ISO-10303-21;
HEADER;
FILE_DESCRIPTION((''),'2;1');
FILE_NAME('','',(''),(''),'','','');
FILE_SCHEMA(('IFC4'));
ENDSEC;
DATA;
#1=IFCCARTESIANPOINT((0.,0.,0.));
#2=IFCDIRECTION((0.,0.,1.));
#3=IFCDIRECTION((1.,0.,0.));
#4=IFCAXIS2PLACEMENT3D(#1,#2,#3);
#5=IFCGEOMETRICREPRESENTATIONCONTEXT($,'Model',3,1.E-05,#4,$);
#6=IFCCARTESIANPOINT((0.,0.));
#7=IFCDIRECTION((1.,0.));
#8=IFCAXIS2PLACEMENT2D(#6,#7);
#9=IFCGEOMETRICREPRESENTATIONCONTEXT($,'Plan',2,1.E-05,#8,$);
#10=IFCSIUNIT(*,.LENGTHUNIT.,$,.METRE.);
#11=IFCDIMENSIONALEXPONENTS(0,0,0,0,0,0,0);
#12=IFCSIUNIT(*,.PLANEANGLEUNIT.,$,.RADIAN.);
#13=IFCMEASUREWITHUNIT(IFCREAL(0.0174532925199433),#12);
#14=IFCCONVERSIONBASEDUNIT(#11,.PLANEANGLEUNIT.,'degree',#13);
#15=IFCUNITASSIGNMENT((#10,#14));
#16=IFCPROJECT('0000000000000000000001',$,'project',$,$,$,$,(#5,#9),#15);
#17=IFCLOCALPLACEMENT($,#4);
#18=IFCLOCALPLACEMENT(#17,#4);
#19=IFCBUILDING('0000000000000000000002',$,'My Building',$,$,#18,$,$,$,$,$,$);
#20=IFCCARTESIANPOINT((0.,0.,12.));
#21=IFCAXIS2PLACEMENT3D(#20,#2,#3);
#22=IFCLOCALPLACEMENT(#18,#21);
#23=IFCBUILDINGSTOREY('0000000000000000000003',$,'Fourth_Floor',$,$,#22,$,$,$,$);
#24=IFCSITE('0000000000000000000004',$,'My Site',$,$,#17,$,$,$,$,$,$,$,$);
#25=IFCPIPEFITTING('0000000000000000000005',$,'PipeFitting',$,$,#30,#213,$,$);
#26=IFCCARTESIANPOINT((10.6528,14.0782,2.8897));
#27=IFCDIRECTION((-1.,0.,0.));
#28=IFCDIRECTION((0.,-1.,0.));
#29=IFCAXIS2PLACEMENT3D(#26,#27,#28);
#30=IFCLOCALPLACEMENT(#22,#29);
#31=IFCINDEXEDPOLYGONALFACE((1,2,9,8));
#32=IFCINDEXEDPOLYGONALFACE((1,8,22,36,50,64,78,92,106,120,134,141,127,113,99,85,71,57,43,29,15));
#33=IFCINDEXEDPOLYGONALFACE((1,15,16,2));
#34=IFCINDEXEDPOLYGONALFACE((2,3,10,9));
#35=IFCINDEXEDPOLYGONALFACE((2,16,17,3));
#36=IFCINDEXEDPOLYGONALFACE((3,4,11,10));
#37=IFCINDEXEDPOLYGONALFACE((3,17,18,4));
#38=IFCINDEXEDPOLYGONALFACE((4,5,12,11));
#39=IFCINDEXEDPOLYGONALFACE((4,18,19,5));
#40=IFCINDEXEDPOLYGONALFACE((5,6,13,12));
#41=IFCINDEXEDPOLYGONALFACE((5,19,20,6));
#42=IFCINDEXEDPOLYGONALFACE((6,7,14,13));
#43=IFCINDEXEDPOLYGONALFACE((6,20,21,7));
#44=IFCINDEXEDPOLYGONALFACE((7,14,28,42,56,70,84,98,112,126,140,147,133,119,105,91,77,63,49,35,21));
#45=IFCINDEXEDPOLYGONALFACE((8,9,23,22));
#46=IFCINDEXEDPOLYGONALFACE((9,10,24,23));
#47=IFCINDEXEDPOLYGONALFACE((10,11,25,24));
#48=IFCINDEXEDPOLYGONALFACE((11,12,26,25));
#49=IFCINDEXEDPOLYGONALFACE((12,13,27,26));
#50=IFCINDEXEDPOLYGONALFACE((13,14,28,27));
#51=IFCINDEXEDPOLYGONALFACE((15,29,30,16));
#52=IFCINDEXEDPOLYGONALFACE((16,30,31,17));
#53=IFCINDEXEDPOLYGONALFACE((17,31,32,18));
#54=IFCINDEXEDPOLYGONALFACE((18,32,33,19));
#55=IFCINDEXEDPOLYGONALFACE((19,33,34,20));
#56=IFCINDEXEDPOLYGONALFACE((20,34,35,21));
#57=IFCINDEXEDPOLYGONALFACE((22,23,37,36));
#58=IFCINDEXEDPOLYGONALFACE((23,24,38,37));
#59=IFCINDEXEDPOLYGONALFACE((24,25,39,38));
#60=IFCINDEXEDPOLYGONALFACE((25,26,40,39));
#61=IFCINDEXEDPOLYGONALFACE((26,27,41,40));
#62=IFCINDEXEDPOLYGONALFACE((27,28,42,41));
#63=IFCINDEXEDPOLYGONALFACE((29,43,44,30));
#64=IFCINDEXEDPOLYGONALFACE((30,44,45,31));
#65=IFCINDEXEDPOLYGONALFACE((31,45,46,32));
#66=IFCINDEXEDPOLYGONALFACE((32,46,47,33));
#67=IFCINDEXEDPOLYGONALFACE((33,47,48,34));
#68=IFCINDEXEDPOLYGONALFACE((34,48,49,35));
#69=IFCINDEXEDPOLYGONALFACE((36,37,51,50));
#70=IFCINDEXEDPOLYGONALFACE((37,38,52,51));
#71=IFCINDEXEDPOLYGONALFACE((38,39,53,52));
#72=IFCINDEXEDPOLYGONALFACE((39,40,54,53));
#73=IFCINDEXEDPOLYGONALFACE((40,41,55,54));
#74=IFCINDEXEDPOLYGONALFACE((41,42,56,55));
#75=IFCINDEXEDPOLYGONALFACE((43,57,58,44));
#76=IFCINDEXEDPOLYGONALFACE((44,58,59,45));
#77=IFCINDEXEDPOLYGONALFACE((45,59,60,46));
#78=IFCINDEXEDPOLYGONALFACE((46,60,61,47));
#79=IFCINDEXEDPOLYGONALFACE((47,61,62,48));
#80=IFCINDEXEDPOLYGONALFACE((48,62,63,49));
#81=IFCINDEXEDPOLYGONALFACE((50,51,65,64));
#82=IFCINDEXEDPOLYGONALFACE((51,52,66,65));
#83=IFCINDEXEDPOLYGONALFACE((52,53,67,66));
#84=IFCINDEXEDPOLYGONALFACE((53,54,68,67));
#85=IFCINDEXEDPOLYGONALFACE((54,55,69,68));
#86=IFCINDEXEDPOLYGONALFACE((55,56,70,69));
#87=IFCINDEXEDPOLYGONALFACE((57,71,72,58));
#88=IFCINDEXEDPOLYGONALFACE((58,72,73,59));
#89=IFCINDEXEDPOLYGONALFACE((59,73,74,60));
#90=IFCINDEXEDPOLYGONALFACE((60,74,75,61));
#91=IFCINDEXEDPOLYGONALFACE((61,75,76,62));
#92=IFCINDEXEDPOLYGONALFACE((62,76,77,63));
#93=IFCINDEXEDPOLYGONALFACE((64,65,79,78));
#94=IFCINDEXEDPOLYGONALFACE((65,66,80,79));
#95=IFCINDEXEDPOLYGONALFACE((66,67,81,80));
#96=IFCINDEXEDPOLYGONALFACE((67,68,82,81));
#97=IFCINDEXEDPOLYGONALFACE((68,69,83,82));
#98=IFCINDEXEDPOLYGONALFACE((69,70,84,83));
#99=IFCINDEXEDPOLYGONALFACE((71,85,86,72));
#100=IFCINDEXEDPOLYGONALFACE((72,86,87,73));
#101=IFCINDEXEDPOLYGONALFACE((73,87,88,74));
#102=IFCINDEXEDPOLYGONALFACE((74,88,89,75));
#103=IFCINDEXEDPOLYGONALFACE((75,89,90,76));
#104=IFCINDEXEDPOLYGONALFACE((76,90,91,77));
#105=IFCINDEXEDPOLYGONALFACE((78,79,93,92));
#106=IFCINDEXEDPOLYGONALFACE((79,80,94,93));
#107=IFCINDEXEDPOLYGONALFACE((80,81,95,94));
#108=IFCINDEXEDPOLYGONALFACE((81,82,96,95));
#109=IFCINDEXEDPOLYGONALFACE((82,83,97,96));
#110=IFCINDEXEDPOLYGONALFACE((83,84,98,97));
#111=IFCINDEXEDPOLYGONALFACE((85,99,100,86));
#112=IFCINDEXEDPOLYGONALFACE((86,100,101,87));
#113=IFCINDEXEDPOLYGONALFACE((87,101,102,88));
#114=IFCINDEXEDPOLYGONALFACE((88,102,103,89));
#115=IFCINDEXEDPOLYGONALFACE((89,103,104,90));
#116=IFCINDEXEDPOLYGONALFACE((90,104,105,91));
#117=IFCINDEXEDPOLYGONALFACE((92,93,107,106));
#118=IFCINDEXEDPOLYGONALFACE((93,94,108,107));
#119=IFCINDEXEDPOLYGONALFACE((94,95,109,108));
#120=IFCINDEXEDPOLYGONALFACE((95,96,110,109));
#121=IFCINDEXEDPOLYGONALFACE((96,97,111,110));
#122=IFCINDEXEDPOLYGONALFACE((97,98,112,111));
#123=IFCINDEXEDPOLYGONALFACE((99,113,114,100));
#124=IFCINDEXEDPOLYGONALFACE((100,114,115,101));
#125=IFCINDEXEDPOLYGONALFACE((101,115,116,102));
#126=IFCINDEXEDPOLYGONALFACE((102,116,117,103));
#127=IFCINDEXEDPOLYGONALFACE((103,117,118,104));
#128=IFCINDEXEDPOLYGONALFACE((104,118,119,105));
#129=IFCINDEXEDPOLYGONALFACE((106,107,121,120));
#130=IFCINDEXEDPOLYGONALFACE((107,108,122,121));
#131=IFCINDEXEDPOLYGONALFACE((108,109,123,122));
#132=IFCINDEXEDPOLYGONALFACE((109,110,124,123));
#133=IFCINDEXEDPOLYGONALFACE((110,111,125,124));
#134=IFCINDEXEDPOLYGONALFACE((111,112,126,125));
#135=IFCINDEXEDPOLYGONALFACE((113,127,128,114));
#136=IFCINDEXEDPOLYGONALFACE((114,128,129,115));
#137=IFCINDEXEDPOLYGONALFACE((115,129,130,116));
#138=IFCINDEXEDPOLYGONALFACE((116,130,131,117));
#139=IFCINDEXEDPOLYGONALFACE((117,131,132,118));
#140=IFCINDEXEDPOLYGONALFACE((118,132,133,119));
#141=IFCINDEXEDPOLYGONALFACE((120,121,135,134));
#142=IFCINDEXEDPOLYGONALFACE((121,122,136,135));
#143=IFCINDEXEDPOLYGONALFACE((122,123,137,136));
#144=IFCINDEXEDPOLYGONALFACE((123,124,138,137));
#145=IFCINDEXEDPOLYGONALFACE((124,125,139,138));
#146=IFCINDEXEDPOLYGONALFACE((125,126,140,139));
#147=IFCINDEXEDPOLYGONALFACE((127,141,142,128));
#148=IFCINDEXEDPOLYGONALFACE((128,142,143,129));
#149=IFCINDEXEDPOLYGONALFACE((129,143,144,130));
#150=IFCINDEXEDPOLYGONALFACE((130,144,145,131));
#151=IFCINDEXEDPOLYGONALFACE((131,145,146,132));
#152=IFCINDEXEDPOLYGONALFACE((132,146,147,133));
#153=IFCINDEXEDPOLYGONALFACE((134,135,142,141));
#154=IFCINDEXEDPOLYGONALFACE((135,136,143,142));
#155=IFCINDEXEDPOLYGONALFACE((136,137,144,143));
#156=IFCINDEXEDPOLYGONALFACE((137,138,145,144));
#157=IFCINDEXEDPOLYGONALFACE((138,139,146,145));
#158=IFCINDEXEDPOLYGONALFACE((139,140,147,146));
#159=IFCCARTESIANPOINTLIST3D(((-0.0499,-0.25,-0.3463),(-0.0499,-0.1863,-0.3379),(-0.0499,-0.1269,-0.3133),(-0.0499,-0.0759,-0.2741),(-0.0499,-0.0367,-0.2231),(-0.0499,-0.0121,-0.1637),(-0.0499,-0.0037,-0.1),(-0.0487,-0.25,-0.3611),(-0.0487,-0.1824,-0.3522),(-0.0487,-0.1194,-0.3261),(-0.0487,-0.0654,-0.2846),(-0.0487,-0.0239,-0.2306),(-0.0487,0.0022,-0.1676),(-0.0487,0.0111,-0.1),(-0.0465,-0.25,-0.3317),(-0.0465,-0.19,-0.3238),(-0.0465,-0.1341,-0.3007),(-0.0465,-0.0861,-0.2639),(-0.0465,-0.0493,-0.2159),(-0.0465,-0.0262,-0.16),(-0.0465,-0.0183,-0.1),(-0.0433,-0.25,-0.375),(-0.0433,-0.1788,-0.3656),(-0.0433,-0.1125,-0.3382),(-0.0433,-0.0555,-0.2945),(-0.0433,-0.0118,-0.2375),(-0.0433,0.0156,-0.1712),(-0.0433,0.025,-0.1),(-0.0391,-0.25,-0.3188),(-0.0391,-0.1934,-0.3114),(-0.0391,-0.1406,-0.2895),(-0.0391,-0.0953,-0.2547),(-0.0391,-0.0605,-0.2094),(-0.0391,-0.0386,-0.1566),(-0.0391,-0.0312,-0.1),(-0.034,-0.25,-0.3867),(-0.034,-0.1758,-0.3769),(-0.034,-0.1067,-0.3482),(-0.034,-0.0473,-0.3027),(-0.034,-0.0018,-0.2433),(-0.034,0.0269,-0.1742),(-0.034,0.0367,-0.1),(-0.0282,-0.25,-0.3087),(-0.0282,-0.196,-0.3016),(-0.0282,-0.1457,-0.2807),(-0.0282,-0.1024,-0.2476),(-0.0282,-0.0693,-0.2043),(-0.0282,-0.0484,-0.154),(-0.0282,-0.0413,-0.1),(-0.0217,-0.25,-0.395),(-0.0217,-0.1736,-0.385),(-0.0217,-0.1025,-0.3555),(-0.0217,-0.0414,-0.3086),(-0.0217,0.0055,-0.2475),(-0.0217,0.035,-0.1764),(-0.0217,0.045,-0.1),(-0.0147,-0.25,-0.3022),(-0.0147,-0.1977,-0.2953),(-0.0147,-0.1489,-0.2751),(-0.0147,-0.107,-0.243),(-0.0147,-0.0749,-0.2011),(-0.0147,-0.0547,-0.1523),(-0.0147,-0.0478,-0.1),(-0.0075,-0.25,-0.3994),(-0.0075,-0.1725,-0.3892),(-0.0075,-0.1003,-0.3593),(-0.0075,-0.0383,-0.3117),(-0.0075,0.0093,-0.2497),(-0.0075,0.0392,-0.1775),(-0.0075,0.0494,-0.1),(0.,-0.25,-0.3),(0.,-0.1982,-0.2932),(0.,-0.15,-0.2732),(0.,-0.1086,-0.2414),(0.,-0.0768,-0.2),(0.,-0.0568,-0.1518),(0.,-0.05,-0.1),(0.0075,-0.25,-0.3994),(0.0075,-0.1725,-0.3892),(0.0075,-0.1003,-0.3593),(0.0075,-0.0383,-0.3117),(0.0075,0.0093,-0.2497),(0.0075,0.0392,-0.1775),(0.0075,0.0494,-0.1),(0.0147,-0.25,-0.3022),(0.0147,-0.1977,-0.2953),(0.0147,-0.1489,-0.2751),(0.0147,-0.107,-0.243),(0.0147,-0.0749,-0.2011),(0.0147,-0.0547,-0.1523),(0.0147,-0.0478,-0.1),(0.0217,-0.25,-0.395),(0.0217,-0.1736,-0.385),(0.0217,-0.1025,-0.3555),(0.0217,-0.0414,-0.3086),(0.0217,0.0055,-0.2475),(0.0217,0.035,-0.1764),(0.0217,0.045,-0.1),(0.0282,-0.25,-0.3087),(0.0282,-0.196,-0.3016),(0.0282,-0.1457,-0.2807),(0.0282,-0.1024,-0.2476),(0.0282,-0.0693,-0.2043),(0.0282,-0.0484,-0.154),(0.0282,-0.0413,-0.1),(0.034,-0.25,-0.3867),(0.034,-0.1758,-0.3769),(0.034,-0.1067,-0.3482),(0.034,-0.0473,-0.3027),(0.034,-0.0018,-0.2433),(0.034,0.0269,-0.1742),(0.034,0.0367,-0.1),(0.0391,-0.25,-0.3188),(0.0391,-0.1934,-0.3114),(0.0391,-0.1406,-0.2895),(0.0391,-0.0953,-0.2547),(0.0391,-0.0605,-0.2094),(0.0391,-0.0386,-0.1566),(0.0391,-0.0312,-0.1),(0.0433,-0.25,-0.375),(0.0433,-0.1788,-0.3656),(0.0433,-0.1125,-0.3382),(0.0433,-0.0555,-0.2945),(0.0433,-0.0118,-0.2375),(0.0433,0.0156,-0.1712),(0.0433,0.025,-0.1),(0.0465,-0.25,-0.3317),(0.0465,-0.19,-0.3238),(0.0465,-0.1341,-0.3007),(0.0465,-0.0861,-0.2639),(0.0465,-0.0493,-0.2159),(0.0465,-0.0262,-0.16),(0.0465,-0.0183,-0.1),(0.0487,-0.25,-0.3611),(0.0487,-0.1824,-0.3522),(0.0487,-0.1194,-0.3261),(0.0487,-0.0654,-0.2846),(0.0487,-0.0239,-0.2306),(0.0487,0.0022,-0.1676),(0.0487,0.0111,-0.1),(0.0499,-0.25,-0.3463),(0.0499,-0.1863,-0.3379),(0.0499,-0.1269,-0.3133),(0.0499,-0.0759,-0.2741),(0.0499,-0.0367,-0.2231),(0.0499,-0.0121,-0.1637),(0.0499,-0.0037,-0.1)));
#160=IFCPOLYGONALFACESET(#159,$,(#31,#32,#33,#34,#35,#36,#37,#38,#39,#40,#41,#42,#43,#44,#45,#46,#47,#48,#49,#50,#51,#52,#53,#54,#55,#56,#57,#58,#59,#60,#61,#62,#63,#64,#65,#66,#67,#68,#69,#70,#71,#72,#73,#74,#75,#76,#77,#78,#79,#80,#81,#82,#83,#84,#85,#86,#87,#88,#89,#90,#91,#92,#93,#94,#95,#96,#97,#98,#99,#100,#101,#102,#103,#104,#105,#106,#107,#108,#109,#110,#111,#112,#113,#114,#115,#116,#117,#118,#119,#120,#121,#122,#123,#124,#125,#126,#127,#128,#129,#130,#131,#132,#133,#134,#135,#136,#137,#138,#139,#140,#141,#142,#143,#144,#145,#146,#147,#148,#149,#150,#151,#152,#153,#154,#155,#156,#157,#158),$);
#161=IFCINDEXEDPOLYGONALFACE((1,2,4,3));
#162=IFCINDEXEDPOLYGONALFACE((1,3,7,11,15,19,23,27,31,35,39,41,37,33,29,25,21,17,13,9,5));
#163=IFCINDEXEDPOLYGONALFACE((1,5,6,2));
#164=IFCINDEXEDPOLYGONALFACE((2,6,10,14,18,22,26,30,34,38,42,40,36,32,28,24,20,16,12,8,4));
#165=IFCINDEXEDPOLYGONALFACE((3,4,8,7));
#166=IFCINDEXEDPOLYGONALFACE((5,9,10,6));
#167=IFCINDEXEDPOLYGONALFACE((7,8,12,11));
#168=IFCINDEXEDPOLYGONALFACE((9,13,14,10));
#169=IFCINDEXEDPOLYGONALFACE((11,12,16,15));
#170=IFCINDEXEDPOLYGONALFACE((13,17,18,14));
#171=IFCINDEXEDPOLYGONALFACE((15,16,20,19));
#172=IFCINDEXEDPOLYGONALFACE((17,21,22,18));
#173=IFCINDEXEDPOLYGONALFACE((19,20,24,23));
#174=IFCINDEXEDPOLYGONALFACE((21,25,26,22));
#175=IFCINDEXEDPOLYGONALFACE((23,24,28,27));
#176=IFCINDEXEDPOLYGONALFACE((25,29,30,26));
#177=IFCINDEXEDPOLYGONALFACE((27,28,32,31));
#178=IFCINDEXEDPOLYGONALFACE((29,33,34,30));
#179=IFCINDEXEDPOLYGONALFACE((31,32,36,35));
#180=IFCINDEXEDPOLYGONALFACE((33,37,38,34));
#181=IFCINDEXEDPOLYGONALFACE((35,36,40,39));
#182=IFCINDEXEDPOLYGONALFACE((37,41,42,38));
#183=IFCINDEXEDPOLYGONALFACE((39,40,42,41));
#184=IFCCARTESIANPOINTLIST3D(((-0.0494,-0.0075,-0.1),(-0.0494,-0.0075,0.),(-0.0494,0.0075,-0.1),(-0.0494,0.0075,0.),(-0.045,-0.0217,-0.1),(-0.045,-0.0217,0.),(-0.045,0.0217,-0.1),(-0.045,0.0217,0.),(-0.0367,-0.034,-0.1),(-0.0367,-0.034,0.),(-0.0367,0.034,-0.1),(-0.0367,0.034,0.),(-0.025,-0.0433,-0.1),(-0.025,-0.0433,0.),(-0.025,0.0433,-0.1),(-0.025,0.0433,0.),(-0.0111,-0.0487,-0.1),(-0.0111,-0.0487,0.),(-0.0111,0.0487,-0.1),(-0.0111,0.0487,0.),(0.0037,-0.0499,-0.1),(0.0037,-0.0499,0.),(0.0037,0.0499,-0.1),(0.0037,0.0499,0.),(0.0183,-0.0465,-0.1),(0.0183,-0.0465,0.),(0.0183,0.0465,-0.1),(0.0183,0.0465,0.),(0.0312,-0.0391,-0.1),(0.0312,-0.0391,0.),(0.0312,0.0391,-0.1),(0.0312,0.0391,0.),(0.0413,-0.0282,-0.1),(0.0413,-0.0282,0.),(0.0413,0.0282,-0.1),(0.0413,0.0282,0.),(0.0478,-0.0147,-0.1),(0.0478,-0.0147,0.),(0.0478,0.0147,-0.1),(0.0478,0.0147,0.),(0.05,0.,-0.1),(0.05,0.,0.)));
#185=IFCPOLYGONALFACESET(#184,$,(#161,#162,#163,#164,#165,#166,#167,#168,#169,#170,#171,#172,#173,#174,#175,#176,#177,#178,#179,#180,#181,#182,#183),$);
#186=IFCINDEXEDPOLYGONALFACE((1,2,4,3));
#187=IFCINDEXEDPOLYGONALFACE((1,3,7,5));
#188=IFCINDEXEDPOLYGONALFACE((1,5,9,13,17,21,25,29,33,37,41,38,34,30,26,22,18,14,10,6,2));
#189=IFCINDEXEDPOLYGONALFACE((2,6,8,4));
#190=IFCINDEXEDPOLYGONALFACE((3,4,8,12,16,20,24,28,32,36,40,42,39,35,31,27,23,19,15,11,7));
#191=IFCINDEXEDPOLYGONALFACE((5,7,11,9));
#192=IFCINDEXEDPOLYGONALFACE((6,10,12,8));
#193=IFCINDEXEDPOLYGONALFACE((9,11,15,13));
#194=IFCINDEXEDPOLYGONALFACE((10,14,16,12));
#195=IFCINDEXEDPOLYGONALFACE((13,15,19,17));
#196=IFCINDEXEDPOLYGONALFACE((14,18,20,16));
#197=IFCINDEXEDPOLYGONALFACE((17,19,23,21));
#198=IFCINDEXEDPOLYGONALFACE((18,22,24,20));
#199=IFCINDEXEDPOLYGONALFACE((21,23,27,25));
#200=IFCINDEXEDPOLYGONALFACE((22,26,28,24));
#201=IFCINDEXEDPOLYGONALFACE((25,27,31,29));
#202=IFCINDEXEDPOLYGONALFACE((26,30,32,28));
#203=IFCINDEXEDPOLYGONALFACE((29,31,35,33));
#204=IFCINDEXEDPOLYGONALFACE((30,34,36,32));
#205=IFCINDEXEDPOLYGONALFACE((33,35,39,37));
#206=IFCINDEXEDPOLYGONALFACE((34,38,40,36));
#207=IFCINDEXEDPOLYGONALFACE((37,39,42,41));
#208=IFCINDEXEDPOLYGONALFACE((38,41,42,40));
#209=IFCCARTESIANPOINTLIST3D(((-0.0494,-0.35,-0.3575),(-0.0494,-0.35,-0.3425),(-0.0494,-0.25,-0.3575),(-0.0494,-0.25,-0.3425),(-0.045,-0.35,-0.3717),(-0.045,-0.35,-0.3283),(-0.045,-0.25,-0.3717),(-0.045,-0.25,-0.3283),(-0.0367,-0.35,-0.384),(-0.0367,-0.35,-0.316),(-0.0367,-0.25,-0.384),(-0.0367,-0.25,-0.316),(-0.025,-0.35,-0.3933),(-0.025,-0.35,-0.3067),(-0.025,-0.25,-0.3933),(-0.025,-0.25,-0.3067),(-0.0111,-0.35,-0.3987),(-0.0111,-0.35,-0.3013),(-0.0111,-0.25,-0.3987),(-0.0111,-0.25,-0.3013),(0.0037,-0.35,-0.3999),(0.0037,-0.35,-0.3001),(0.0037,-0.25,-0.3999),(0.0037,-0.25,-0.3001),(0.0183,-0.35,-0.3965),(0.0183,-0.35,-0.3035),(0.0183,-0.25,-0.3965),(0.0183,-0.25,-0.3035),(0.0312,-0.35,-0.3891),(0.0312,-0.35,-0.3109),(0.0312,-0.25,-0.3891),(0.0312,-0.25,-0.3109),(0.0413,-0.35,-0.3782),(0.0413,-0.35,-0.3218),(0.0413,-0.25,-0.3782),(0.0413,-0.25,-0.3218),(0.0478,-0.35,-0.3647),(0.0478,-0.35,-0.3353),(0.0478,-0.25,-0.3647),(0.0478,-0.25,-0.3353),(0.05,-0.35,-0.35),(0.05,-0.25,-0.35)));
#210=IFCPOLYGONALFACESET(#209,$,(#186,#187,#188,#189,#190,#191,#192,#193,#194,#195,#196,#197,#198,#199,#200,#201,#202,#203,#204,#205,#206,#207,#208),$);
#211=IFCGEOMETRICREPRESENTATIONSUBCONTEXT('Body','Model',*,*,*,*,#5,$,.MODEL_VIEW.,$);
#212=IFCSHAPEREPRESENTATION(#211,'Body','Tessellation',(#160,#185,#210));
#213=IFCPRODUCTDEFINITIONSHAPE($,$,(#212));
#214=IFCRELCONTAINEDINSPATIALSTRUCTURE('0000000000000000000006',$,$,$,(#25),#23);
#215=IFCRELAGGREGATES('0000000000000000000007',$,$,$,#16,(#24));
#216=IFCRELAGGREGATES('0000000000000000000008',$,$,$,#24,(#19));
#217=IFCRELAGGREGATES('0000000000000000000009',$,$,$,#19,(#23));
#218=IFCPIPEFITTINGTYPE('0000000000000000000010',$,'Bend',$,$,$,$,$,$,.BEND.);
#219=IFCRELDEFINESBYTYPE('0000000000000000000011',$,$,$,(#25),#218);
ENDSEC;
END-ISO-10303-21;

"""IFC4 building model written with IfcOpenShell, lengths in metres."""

from ifc_helpers import new_model, entity, si_unit, converted_unit, frame, origin_with_axes, origin_2d_with_axis, place, context, subcontext, project, spatial, circle, extrude, source, transform, mapped, type_object, type_shapes, element, save


model = new_model("IFC4")

# Units and contexts
model_context = context("Model", 3, precision=1e-05, world=origin_with_axes())
plan_context = context("Plan", 2, precision=1e-05, world=origin_2d_with_axis())
body_context_1 = subcontext(model_context, "Body", "Model", "MODEL_VIEW")
ifc_project = project(units=[si_unit("LENGTHUNIT", "METRE"), converted_unit("PLANEANGLEUNIT", "degree", entity("IfcReal", 0.0174532925199433), si_unit("PLANEANGLEUNIT", "RADIAN"), dimensions=[0, 0, 0, 0, 0, 0, 0])], contexts=[model_context, plan_context])

# Site, building, storey
site_placement = place(None, origin_with_axes())
site = spatial("IfcSite", under=ifc_project, at=site_placement, Name="My Site")
building_placement = place(site_placement, origin_with_axes())
building = spatial("IfcBuilding", under=site, at=building_placement, Name="My Building")
storey_placement = place(building_placement, frame((0.0, 0.0, 12.0), z_axis=(0.0, 0.0, 1.0), x_axis=(1.0, 0.0, 0.0)))
storey = spatial("IfcBuildingStorey", under=building, at=storey_placement, Name="Fourth_Floor")

# Pipe fitting
pipe_fitting_type = type_object("IfcPipeFittingType", Name="Bend", PredefinedType="BEND")
shared_shape_1 = source(origin_with_axes(), body_context_1, "Body", "SolidModel", [
    entity("IfcSweptDiskSolid", entity("IfcIndexedPolyCurve", entity("IfcCartesianPointList3D", [[0.0, 0.0, -0.1], [0.0, -0.0732, -0.2768], [0.0, -0.25, -0.35]]), [entity("IfcArcIndex", [1, 2, 3])]), 0.05),
    extrude(circle(Radius=0.05), origin_with_axes(), (0.0, 0.0, -1.0), 0.1),
    extrude(circle(Radius=0.05), frame((0.0, -0.25, -0.35), z_axis=(0.0, -1.0, 0.0), x_axis=(1.0, 0.0, 0.0)), (0.0, 0.0, 1.0), 0.1),
])
type_shapes(pipe_fitting_type, [shared_shape_1])
for number, where, z_axis, x_axis, name in (
    (1, (10.6528, 14.0782, 2.8897), (-1.0, 0.0, 0.0), (0.0, -1.0, 0.0), "PipeFitting"),
):
    element("IfcPipeFitting", number, at=place(storey_placement, frame(where, z_axis=z_axis, x_axis=x_axis)), inside=storey, type_object=pipe_fitting_type, Name=name, context=body_context_1, shape_type="MappedRepresentation", body=[
        mapped(shared_shape_1, transform((0.0, 0.0, 0.0), x_axis=(1.0, 0.0, 0.0), y_axis=(0.0, 1.0, 0.0), z_axis=(0.0, 0.0, 1.0), scale=1.0)),
    ])

save(model, "model.ifc")
